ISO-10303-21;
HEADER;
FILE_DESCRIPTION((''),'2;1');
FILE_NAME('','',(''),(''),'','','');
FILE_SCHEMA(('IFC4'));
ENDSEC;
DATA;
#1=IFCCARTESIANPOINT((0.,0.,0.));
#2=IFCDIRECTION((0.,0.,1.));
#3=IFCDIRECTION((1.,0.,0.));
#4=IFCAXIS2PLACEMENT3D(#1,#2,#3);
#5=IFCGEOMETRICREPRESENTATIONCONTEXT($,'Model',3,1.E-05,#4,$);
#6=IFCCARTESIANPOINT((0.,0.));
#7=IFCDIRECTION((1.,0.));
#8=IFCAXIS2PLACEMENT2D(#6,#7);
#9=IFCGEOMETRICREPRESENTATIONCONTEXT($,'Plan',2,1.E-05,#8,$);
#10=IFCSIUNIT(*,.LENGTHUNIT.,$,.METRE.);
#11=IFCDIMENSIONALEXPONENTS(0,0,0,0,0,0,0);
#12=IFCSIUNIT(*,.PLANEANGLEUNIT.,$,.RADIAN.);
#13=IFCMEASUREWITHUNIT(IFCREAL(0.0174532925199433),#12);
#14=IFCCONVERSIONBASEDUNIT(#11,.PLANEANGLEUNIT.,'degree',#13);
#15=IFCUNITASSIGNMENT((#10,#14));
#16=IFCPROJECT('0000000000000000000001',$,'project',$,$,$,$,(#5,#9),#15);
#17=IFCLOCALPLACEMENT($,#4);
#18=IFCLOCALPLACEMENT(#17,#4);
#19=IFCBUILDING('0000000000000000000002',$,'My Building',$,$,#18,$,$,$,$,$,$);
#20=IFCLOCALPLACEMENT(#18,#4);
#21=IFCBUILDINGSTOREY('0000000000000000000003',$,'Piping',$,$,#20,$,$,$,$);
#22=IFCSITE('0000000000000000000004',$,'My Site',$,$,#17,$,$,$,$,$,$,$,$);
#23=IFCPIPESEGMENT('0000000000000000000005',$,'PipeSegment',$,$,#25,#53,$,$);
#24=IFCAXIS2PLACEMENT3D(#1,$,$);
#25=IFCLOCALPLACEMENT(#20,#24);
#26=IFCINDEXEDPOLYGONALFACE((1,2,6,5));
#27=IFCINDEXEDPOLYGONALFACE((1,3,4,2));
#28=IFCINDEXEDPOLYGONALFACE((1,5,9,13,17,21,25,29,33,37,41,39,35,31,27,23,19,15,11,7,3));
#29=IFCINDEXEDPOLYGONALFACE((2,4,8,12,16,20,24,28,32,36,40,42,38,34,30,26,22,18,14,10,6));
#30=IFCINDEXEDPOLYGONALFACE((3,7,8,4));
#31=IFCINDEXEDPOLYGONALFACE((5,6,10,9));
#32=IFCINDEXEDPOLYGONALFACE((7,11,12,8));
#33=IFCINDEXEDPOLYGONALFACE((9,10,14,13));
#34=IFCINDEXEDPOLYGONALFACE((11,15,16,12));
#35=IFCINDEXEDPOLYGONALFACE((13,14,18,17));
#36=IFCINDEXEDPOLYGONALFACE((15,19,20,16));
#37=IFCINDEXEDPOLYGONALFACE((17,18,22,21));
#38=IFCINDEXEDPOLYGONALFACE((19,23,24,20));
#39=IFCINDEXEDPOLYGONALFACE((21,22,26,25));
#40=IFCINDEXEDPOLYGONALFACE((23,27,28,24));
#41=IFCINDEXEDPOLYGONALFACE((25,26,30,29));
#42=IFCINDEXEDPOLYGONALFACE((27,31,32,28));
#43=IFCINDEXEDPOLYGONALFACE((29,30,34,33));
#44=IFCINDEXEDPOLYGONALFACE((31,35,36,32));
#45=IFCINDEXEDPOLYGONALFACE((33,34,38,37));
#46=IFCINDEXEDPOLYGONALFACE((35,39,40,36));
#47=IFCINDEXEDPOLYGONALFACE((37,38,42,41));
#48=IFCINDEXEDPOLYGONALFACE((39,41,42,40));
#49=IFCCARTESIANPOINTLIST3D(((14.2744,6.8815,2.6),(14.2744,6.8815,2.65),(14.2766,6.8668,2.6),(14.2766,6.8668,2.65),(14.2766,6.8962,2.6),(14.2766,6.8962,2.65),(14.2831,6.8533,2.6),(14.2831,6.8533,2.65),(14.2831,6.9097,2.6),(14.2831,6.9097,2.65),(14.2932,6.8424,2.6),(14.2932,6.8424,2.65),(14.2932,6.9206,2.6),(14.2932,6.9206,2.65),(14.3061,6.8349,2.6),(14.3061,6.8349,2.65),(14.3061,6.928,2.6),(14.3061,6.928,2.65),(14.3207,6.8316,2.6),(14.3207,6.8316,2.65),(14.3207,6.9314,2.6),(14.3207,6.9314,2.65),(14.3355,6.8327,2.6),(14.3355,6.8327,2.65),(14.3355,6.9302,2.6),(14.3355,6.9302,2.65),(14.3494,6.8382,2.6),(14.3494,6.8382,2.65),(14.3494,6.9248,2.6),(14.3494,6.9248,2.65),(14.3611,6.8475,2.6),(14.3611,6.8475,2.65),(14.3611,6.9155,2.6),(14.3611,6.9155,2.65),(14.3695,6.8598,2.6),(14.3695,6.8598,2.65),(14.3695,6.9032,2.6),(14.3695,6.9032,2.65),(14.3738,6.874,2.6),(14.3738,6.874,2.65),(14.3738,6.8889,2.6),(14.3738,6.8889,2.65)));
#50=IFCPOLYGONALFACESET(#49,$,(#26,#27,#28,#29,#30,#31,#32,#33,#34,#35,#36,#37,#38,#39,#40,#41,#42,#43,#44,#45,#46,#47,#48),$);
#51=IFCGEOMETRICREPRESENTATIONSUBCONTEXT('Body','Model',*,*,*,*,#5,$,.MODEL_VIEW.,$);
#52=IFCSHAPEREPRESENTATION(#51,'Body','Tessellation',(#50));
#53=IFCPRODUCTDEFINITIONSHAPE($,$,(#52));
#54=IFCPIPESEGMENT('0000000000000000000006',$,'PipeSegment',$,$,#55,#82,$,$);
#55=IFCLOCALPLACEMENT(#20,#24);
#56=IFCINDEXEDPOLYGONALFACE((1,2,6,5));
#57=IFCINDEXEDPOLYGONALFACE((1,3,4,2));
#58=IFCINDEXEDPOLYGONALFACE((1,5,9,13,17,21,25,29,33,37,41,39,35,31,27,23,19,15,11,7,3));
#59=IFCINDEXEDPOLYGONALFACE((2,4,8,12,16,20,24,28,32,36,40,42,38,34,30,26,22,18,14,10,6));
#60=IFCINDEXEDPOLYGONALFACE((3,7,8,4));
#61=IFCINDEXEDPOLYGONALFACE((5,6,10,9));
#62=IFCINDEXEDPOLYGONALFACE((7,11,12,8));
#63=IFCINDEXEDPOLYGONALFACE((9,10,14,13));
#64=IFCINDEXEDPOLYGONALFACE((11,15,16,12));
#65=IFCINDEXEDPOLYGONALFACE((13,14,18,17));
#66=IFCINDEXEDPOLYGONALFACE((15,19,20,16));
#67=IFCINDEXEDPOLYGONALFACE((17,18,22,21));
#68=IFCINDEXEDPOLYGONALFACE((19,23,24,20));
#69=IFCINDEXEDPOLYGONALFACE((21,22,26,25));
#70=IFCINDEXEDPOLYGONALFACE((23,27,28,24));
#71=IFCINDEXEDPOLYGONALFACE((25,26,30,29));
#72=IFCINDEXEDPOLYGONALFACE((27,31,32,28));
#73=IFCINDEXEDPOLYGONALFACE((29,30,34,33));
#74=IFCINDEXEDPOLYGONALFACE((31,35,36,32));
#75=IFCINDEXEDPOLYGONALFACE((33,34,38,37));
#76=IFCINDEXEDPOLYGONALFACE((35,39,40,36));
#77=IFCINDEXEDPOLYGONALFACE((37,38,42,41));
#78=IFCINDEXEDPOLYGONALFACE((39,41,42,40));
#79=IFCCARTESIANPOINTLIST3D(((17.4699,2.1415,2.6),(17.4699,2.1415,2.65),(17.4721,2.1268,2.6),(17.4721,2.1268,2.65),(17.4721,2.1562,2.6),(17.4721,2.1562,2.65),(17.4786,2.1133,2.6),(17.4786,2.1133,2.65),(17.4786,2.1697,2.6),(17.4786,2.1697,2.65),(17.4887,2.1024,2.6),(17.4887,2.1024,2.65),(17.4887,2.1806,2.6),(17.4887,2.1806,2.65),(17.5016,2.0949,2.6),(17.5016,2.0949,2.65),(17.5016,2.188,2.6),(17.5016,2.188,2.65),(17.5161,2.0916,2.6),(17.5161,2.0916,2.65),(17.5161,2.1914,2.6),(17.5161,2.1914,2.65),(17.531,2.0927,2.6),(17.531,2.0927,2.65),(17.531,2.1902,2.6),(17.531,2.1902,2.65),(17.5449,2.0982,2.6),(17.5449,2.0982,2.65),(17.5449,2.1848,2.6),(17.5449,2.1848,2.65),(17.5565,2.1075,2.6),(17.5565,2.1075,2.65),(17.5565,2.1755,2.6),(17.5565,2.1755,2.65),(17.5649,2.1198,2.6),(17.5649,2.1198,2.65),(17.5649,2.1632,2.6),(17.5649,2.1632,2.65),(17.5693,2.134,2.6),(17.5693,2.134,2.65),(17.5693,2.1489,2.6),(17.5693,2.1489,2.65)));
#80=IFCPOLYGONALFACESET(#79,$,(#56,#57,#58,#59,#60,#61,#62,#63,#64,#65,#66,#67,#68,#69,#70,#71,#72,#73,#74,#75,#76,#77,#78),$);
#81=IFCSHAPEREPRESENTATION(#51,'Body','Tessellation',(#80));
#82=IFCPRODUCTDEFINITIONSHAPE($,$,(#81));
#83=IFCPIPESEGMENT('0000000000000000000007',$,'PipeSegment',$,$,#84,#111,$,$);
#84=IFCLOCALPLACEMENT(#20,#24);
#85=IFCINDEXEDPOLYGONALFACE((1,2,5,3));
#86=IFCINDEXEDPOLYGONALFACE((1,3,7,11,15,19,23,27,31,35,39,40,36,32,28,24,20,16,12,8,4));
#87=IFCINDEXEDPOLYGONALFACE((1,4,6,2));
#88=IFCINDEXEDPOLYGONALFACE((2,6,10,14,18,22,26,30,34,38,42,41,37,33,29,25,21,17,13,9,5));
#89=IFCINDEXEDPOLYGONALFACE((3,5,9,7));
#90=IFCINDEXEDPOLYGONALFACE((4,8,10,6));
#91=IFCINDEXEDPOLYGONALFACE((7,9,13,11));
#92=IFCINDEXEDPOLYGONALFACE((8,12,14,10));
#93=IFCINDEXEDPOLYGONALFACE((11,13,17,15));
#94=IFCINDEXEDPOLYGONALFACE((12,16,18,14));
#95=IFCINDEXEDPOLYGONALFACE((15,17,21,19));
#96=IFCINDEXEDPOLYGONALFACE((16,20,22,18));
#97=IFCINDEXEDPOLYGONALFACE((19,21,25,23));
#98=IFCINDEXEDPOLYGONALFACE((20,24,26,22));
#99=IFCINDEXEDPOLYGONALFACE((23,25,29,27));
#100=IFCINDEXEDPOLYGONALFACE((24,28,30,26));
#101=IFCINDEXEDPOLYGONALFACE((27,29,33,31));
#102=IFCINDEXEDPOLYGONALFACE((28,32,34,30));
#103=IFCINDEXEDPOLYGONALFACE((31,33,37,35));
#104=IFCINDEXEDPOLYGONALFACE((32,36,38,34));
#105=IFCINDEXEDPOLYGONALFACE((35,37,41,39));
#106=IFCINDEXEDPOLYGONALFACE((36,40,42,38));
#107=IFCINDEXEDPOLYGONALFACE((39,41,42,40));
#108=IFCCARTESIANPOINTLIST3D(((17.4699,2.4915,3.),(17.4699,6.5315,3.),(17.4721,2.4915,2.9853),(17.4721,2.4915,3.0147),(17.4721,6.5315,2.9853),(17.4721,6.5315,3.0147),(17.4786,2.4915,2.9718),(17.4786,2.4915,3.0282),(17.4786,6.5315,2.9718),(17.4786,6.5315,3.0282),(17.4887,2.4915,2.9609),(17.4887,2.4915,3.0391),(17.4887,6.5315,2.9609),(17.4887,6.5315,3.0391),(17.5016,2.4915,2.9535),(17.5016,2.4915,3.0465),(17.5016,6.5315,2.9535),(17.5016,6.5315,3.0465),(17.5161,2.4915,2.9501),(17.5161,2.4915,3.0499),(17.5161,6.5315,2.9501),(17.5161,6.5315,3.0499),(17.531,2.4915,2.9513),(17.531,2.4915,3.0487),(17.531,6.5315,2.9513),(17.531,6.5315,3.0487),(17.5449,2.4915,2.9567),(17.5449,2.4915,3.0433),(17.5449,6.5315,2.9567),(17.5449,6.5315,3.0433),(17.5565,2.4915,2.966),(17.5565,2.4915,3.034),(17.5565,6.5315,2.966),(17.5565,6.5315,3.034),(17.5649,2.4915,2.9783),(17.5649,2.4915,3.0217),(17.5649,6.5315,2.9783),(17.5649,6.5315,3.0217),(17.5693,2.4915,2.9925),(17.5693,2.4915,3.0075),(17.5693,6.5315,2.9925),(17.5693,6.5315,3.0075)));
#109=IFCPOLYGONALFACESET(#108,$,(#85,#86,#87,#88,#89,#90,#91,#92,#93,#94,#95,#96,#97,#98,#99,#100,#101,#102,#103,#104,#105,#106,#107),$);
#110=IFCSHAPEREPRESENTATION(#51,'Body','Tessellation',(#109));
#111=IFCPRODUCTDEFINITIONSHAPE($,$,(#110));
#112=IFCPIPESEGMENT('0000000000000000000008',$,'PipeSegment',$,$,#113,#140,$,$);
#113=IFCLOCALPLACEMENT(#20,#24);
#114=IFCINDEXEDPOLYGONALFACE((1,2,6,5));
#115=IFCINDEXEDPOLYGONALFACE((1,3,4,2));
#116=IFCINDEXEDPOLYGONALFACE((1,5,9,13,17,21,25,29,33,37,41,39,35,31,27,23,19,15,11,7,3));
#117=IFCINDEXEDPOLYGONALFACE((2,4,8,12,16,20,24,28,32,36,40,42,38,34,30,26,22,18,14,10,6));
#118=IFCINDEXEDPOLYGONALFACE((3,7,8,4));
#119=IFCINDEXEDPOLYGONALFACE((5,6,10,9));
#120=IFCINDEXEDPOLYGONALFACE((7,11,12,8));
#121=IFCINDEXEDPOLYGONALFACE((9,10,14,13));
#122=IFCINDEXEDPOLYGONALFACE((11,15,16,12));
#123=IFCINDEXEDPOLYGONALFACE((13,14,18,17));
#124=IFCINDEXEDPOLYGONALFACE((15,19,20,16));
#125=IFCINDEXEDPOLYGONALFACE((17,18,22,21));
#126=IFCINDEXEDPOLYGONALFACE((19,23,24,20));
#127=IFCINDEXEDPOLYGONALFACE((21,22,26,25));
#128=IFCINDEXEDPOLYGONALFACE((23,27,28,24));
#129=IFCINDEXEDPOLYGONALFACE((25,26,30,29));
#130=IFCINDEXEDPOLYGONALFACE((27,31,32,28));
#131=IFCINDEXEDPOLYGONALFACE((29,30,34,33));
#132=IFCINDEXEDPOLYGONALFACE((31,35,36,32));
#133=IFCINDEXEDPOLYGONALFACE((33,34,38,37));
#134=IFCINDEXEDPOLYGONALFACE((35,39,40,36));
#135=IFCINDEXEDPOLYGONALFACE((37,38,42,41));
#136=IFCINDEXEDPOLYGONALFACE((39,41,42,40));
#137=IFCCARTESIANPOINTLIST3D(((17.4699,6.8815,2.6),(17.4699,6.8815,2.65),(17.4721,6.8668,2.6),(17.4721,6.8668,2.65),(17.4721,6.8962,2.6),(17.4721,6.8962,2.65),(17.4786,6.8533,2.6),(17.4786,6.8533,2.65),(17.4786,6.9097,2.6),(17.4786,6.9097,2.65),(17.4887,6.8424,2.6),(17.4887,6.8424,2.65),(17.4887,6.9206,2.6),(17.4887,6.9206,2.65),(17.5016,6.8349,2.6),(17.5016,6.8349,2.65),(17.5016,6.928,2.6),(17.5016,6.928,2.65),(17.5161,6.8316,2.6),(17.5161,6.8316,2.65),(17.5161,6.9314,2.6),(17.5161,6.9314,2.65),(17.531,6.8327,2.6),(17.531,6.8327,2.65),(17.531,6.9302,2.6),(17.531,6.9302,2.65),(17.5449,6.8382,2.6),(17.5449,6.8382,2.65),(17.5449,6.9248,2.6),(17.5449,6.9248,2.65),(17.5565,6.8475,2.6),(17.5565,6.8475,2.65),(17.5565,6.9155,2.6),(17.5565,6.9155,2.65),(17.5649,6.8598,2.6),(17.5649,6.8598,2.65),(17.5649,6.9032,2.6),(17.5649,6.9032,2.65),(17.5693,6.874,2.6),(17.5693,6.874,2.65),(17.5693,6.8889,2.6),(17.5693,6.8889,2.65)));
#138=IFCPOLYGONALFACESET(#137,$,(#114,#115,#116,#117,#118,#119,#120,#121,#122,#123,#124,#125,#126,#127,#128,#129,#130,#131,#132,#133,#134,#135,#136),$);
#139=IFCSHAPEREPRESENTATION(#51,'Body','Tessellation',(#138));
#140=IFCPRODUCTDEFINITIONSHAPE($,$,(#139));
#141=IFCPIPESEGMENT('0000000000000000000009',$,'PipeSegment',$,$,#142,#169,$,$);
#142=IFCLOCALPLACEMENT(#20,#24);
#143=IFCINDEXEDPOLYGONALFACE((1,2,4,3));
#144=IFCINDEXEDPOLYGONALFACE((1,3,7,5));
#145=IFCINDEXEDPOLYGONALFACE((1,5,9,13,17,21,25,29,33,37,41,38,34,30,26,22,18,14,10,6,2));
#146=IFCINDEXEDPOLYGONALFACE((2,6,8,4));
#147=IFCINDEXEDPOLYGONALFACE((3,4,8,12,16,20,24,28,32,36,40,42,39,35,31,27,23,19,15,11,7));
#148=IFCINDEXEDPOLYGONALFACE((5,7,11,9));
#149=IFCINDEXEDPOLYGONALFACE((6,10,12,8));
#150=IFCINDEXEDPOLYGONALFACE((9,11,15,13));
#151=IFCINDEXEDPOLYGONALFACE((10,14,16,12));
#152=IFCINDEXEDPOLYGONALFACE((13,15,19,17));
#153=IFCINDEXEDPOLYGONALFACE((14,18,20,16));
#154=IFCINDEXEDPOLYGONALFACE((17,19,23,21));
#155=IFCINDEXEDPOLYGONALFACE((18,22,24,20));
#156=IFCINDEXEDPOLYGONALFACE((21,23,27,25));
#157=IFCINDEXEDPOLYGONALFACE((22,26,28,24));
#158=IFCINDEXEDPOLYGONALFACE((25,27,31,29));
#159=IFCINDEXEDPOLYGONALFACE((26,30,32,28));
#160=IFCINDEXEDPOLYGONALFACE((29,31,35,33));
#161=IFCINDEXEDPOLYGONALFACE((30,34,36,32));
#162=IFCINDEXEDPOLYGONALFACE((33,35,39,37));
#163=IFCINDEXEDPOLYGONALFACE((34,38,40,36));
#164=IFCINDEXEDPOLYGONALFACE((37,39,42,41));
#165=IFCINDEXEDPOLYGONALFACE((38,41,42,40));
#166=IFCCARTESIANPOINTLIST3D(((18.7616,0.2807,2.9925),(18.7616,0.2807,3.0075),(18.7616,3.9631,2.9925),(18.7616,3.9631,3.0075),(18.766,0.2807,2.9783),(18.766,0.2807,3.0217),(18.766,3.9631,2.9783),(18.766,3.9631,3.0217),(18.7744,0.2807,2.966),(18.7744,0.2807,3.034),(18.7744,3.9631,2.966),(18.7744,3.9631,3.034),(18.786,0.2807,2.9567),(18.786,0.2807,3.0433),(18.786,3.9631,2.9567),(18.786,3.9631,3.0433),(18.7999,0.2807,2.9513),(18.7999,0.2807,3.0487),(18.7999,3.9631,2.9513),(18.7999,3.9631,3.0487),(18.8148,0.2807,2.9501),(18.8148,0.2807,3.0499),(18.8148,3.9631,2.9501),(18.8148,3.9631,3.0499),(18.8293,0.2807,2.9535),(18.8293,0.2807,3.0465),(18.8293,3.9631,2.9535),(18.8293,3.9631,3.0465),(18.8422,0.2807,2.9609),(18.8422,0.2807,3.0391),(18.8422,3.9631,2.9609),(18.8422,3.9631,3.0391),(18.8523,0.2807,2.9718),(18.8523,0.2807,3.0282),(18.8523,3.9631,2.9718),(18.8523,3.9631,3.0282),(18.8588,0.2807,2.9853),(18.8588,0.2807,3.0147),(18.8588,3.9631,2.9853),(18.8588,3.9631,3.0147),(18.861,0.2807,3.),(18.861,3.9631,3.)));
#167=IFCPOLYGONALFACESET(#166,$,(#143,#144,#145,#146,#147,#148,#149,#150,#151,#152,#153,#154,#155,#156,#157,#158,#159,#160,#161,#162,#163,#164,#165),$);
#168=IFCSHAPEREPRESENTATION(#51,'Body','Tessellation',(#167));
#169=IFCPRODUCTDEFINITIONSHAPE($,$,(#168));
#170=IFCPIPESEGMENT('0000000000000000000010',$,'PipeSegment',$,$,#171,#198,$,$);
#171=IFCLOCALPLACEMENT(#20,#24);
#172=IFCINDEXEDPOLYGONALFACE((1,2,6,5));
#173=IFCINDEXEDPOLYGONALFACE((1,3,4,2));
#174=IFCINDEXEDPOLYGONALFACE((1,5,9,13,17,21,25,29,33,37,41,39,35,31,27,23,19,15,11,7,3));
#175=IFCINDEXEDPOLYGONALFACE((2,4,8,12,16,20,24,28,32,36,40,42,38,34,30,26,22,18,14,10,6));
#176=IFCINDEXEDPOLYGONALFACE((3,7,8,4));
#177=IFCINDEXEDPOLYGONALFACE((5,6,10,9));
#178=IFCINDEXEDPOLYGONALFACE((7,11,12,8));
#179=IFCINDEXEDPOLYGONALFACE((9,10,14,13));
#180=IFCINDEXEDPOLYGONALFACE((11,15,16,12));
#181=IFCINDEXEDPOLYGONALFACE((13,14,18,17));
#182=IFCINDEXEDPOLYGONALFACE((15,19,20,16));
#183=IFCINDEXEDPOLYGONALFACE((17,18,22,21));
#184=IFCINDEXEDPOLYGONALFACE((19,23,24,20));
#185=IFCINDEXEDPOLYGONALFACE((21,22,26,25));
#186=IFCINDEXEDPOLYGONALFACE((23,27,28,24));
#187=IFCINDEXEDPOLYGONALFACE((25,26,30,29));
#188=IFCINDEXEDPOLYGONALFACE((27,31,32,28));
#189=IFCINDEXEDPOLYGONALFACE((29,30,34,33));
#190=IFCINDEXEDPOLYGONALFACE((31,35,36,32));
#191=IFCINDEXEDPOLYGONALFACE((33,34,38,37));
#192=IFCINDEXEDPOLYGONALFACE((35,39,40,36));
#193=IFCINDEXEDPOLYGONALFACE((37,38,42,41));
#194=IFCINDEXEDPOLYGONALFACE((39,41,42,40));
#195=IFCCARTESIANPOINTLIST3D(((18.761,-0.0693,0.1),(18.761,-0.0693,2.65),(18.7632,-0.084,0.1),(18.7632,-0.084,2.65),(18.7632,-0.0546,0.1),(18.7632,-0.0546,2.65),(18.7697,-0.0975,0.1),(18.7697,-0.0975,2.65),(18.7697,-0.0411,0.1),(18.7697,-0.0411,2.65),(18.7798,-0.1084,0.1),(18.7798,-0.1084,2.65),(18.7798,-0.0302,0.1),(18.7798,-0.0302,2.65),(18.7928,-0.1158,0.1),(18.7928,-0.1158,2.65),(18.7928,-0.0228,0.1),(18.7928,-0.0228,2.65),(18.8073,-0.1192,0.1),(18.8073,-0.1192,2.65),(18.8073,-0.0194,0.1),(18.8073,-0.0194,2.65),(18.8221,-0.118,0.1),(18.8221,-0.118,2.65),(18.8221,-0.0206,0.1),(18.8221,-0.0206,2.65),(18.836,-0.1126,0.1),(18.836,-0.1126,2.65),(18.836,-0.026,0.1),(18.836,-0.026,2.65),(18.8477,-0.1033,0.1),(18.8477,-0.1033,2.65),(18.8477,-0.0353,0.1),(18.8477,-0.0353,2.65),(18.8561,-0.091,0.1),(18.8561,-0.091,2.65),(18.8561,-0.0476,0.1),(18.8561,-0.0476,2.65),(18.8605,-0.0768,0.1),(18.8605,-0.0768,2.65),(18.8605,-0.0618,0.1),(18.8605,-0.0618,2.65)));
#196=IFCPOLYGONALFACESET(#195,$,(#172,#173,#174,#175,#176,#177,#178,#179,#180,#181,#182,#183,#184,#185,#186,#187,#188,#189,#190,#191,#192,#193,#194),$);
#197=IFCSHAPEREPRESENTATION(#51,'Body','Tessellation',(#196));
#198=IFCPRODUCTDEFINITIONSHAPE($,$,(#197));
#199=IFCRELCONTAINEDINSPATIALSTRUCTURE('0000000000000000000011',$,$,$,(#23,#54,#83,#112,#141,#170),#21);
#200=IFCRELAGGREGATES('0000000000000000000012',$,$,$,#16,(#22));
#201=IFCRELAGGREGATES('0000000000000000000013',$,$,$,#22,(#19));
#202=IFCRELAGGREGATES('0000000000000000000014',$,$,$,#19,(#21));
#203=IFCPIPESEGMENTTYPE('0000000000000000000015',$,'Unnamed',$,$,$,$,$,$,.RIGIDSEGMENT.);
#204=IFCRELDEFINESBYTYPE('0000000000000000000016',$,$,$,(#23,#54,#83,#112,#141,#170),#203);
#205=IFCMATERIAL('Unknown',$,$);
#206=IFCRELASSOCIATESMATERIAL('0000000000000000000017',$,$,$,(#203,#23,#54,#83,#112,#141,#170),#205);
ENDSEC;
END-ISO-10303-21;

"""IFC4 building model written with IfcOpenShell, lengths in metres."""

from ifc_helpers import new_model, entity, si_unit, converted_unit, frame, origin_with_axes, origin_2d_with_axis, place, context, subcontext, project, spatial, circle, extrude, material, material_profile, profile_set, profile_usage, type_object, element, save


model = new_model("IFC4")

# Units and contexts
model_context = context("Model", 3, precision=1e-05, world=origin_with_axes())
plan_context = context("Plan", 2, precision=1e-05, world=origin_2d_with_axis())
body_context = subcontext(model_context, "Body", "Model", "MODEL_VIEW")
ifc_project = project(units=[si_unit("LENGTHUNIT", "METRE"), converted_unit("PLANEANGLEUNIT", "degree", entity("IfcReal", 0.0174532925199433), si_unit("PLANEANGLEUNIT", "RADIAN"), dimensions=[0, 0, 0, 0, 0, 0, 0])], contexts=[model_context, plan_context])

# Site, building, storey
site_placement = place(None, origin_with_axes())
site = spatial("IfcSite", under=ifc_project, at=site_placement, Name="My Site")
building_placement = place(site_placement, origin_with_axes())
building = spatial("IfcBuilding", under=site, at=building_placement, Name="My Building")
storey_placement = place(building_placement, origin_with_axes())
storey = spatial("IfcBuildingStorey", under=building, at=storey_placement, Name="Piping")

# Pipe segments
ifc_material = material(Name="Unknown")
ifc_material_profile_1 = material_profile(ifc_material, circle(Radius=0.05))
ifc_profile_set_1 = profile_set([ifc_material_profile_1])
pipe_segment_type = type_object("IfcPipeSegmentType", Name="Unnamed", PredefinedType="RIGIDSEGMENT", material=ifc_profile_set_1)
ifc_profile_usage_1 = profile_usage(ifc_profile_set_1, cardinal=5)
pipe_segment_1_placement = place(storey_placement, frame((14.3244, 6.8815, 2.65), z_axis=(0.0, 0.0, -1.0), x_axis=(-1.0, 0.0, 0.0)))
element("IfcPipeSegment", 1, at=pipe_segment_1_placement, inside=storey, type_object=pipe_segment_type, material=ifc_profile_usage_1, Name="PipeSegment", context=body_context, shape_type="SweptSolid", body=[
    extrude(circle(Radius=0.05), origin_with_axes(), (0.0, 0.0, 1.0), 0.05),
])
ifc_profile_usage_2 = profile_usage(ifc_profile_set_1, cardinal=5)
pipe_segment_2_placement = place(storey_placement, frame((17.5199, 2.1415, 2.65), z_axis=(0.0, 0.0, -1.0), x_axis=(-1.0, 0.0, 0.0)))
element("IfcPipeSegment", 2, at=pipe_segment_2_placement, inside=storey, type_object=pipe_segment_type, material=ifc_profile_usage_2, Name="PipeSegment", context=body_context, shape_type="SweptSolid", body=[
    extrude(circle(Radius=0.05), origin_with_axes(), (0.0, 0.0, 1.0), 0.05),
])
ifc_profile_usage_3 = profile_usage(ifc_profile_set_1, cardinal=5)
pipe_segment_3_placement = place(storey_placement, frame((17.5199, 2.4915, 3.0), z_axis=(0.0, 1.0, 0.0), x_axis=(-1.0, 0.0, 0.0)))
element("IfcPipeSegment", 3, at=pipe_segment_3_placement, inside=storey, type_object=pipe_segment_type, material=ifc_profile_usage_3, Name="PipeSegment", context=body_context, shape_type="SweptSolid", body=[
    extrude(circle(Radius=0.05), origin_with_axes(), (0.0, 0.0, 1.0), 4.04),
])
ifc_profile_usage_4 = profile_usage(ifc_profile_set_1, cardinal=5)
pipe_segment_4_placement = place(storey_placement, frame((17.5199, 6.8815, 2.65), z_axis=(0.0, 0.0, -1.0), x_axis=(-1.0, 0.0, 0.0)))
element("IfcPipeSegment", 4, at=pipe_segment_4_placement, inside=storey, type_object=pipe_segment_type, material=ifc_profile_usage_4, Name="PipeSegment", context=body_context, shape_type="SweptSolid", body=[
    extrude(circle(Radius=0.05), origin_with_axes(), (0.0, 0.0, 1.0), 0.05),
])
ifc_profile_usage_5 = profile_usage(ifc_profile_set_1, cardinal=5)
pipe_segment_5_placement = place(storey_placement, frame((18.811, 3.9631, 3.0), z_axis=(0.0, -1.0, 0.0), x_axis=(1.0, 0.0, 0.0)))
element("IfcPipeSegment", 5, at=pipe_segment_5_placement, inside=storey, type_object=pipe_segment_type, material=ifc_profile_usage_5, Name="PipeSegment", context=body_context, shape_type="SweptSolid", body=[
    extrude(circle(Radius=0.05), origin_with_axes(), (0.0, 0.0, 1.0), 3.6824),
])
ifc_profile_usage_6 = profile_usage(ifc_profile_set_1, cardinal=5)
pipe_segment_6_placement = place(storey_placement, frame((18.811, -0.0693, 2.65), z_axis=(0.0, 0.0, -1.0), x_axis=(-1.0, 0.0, 0.0)))
element("IfcPipeSegment", 6, at=pipe_segment_6_placement, inside=storey, type_object=pipe_segment_type, material=ifc_profile_usage_6, Name="PipeSegment", context=body_context, shape_type="SweptSolid", body=[
    extrude(circle(Radius=0.05), origin_with_axes(), (0.0, 0.0, 1.0), 2.55),
])

save(model, "model.ifc")
